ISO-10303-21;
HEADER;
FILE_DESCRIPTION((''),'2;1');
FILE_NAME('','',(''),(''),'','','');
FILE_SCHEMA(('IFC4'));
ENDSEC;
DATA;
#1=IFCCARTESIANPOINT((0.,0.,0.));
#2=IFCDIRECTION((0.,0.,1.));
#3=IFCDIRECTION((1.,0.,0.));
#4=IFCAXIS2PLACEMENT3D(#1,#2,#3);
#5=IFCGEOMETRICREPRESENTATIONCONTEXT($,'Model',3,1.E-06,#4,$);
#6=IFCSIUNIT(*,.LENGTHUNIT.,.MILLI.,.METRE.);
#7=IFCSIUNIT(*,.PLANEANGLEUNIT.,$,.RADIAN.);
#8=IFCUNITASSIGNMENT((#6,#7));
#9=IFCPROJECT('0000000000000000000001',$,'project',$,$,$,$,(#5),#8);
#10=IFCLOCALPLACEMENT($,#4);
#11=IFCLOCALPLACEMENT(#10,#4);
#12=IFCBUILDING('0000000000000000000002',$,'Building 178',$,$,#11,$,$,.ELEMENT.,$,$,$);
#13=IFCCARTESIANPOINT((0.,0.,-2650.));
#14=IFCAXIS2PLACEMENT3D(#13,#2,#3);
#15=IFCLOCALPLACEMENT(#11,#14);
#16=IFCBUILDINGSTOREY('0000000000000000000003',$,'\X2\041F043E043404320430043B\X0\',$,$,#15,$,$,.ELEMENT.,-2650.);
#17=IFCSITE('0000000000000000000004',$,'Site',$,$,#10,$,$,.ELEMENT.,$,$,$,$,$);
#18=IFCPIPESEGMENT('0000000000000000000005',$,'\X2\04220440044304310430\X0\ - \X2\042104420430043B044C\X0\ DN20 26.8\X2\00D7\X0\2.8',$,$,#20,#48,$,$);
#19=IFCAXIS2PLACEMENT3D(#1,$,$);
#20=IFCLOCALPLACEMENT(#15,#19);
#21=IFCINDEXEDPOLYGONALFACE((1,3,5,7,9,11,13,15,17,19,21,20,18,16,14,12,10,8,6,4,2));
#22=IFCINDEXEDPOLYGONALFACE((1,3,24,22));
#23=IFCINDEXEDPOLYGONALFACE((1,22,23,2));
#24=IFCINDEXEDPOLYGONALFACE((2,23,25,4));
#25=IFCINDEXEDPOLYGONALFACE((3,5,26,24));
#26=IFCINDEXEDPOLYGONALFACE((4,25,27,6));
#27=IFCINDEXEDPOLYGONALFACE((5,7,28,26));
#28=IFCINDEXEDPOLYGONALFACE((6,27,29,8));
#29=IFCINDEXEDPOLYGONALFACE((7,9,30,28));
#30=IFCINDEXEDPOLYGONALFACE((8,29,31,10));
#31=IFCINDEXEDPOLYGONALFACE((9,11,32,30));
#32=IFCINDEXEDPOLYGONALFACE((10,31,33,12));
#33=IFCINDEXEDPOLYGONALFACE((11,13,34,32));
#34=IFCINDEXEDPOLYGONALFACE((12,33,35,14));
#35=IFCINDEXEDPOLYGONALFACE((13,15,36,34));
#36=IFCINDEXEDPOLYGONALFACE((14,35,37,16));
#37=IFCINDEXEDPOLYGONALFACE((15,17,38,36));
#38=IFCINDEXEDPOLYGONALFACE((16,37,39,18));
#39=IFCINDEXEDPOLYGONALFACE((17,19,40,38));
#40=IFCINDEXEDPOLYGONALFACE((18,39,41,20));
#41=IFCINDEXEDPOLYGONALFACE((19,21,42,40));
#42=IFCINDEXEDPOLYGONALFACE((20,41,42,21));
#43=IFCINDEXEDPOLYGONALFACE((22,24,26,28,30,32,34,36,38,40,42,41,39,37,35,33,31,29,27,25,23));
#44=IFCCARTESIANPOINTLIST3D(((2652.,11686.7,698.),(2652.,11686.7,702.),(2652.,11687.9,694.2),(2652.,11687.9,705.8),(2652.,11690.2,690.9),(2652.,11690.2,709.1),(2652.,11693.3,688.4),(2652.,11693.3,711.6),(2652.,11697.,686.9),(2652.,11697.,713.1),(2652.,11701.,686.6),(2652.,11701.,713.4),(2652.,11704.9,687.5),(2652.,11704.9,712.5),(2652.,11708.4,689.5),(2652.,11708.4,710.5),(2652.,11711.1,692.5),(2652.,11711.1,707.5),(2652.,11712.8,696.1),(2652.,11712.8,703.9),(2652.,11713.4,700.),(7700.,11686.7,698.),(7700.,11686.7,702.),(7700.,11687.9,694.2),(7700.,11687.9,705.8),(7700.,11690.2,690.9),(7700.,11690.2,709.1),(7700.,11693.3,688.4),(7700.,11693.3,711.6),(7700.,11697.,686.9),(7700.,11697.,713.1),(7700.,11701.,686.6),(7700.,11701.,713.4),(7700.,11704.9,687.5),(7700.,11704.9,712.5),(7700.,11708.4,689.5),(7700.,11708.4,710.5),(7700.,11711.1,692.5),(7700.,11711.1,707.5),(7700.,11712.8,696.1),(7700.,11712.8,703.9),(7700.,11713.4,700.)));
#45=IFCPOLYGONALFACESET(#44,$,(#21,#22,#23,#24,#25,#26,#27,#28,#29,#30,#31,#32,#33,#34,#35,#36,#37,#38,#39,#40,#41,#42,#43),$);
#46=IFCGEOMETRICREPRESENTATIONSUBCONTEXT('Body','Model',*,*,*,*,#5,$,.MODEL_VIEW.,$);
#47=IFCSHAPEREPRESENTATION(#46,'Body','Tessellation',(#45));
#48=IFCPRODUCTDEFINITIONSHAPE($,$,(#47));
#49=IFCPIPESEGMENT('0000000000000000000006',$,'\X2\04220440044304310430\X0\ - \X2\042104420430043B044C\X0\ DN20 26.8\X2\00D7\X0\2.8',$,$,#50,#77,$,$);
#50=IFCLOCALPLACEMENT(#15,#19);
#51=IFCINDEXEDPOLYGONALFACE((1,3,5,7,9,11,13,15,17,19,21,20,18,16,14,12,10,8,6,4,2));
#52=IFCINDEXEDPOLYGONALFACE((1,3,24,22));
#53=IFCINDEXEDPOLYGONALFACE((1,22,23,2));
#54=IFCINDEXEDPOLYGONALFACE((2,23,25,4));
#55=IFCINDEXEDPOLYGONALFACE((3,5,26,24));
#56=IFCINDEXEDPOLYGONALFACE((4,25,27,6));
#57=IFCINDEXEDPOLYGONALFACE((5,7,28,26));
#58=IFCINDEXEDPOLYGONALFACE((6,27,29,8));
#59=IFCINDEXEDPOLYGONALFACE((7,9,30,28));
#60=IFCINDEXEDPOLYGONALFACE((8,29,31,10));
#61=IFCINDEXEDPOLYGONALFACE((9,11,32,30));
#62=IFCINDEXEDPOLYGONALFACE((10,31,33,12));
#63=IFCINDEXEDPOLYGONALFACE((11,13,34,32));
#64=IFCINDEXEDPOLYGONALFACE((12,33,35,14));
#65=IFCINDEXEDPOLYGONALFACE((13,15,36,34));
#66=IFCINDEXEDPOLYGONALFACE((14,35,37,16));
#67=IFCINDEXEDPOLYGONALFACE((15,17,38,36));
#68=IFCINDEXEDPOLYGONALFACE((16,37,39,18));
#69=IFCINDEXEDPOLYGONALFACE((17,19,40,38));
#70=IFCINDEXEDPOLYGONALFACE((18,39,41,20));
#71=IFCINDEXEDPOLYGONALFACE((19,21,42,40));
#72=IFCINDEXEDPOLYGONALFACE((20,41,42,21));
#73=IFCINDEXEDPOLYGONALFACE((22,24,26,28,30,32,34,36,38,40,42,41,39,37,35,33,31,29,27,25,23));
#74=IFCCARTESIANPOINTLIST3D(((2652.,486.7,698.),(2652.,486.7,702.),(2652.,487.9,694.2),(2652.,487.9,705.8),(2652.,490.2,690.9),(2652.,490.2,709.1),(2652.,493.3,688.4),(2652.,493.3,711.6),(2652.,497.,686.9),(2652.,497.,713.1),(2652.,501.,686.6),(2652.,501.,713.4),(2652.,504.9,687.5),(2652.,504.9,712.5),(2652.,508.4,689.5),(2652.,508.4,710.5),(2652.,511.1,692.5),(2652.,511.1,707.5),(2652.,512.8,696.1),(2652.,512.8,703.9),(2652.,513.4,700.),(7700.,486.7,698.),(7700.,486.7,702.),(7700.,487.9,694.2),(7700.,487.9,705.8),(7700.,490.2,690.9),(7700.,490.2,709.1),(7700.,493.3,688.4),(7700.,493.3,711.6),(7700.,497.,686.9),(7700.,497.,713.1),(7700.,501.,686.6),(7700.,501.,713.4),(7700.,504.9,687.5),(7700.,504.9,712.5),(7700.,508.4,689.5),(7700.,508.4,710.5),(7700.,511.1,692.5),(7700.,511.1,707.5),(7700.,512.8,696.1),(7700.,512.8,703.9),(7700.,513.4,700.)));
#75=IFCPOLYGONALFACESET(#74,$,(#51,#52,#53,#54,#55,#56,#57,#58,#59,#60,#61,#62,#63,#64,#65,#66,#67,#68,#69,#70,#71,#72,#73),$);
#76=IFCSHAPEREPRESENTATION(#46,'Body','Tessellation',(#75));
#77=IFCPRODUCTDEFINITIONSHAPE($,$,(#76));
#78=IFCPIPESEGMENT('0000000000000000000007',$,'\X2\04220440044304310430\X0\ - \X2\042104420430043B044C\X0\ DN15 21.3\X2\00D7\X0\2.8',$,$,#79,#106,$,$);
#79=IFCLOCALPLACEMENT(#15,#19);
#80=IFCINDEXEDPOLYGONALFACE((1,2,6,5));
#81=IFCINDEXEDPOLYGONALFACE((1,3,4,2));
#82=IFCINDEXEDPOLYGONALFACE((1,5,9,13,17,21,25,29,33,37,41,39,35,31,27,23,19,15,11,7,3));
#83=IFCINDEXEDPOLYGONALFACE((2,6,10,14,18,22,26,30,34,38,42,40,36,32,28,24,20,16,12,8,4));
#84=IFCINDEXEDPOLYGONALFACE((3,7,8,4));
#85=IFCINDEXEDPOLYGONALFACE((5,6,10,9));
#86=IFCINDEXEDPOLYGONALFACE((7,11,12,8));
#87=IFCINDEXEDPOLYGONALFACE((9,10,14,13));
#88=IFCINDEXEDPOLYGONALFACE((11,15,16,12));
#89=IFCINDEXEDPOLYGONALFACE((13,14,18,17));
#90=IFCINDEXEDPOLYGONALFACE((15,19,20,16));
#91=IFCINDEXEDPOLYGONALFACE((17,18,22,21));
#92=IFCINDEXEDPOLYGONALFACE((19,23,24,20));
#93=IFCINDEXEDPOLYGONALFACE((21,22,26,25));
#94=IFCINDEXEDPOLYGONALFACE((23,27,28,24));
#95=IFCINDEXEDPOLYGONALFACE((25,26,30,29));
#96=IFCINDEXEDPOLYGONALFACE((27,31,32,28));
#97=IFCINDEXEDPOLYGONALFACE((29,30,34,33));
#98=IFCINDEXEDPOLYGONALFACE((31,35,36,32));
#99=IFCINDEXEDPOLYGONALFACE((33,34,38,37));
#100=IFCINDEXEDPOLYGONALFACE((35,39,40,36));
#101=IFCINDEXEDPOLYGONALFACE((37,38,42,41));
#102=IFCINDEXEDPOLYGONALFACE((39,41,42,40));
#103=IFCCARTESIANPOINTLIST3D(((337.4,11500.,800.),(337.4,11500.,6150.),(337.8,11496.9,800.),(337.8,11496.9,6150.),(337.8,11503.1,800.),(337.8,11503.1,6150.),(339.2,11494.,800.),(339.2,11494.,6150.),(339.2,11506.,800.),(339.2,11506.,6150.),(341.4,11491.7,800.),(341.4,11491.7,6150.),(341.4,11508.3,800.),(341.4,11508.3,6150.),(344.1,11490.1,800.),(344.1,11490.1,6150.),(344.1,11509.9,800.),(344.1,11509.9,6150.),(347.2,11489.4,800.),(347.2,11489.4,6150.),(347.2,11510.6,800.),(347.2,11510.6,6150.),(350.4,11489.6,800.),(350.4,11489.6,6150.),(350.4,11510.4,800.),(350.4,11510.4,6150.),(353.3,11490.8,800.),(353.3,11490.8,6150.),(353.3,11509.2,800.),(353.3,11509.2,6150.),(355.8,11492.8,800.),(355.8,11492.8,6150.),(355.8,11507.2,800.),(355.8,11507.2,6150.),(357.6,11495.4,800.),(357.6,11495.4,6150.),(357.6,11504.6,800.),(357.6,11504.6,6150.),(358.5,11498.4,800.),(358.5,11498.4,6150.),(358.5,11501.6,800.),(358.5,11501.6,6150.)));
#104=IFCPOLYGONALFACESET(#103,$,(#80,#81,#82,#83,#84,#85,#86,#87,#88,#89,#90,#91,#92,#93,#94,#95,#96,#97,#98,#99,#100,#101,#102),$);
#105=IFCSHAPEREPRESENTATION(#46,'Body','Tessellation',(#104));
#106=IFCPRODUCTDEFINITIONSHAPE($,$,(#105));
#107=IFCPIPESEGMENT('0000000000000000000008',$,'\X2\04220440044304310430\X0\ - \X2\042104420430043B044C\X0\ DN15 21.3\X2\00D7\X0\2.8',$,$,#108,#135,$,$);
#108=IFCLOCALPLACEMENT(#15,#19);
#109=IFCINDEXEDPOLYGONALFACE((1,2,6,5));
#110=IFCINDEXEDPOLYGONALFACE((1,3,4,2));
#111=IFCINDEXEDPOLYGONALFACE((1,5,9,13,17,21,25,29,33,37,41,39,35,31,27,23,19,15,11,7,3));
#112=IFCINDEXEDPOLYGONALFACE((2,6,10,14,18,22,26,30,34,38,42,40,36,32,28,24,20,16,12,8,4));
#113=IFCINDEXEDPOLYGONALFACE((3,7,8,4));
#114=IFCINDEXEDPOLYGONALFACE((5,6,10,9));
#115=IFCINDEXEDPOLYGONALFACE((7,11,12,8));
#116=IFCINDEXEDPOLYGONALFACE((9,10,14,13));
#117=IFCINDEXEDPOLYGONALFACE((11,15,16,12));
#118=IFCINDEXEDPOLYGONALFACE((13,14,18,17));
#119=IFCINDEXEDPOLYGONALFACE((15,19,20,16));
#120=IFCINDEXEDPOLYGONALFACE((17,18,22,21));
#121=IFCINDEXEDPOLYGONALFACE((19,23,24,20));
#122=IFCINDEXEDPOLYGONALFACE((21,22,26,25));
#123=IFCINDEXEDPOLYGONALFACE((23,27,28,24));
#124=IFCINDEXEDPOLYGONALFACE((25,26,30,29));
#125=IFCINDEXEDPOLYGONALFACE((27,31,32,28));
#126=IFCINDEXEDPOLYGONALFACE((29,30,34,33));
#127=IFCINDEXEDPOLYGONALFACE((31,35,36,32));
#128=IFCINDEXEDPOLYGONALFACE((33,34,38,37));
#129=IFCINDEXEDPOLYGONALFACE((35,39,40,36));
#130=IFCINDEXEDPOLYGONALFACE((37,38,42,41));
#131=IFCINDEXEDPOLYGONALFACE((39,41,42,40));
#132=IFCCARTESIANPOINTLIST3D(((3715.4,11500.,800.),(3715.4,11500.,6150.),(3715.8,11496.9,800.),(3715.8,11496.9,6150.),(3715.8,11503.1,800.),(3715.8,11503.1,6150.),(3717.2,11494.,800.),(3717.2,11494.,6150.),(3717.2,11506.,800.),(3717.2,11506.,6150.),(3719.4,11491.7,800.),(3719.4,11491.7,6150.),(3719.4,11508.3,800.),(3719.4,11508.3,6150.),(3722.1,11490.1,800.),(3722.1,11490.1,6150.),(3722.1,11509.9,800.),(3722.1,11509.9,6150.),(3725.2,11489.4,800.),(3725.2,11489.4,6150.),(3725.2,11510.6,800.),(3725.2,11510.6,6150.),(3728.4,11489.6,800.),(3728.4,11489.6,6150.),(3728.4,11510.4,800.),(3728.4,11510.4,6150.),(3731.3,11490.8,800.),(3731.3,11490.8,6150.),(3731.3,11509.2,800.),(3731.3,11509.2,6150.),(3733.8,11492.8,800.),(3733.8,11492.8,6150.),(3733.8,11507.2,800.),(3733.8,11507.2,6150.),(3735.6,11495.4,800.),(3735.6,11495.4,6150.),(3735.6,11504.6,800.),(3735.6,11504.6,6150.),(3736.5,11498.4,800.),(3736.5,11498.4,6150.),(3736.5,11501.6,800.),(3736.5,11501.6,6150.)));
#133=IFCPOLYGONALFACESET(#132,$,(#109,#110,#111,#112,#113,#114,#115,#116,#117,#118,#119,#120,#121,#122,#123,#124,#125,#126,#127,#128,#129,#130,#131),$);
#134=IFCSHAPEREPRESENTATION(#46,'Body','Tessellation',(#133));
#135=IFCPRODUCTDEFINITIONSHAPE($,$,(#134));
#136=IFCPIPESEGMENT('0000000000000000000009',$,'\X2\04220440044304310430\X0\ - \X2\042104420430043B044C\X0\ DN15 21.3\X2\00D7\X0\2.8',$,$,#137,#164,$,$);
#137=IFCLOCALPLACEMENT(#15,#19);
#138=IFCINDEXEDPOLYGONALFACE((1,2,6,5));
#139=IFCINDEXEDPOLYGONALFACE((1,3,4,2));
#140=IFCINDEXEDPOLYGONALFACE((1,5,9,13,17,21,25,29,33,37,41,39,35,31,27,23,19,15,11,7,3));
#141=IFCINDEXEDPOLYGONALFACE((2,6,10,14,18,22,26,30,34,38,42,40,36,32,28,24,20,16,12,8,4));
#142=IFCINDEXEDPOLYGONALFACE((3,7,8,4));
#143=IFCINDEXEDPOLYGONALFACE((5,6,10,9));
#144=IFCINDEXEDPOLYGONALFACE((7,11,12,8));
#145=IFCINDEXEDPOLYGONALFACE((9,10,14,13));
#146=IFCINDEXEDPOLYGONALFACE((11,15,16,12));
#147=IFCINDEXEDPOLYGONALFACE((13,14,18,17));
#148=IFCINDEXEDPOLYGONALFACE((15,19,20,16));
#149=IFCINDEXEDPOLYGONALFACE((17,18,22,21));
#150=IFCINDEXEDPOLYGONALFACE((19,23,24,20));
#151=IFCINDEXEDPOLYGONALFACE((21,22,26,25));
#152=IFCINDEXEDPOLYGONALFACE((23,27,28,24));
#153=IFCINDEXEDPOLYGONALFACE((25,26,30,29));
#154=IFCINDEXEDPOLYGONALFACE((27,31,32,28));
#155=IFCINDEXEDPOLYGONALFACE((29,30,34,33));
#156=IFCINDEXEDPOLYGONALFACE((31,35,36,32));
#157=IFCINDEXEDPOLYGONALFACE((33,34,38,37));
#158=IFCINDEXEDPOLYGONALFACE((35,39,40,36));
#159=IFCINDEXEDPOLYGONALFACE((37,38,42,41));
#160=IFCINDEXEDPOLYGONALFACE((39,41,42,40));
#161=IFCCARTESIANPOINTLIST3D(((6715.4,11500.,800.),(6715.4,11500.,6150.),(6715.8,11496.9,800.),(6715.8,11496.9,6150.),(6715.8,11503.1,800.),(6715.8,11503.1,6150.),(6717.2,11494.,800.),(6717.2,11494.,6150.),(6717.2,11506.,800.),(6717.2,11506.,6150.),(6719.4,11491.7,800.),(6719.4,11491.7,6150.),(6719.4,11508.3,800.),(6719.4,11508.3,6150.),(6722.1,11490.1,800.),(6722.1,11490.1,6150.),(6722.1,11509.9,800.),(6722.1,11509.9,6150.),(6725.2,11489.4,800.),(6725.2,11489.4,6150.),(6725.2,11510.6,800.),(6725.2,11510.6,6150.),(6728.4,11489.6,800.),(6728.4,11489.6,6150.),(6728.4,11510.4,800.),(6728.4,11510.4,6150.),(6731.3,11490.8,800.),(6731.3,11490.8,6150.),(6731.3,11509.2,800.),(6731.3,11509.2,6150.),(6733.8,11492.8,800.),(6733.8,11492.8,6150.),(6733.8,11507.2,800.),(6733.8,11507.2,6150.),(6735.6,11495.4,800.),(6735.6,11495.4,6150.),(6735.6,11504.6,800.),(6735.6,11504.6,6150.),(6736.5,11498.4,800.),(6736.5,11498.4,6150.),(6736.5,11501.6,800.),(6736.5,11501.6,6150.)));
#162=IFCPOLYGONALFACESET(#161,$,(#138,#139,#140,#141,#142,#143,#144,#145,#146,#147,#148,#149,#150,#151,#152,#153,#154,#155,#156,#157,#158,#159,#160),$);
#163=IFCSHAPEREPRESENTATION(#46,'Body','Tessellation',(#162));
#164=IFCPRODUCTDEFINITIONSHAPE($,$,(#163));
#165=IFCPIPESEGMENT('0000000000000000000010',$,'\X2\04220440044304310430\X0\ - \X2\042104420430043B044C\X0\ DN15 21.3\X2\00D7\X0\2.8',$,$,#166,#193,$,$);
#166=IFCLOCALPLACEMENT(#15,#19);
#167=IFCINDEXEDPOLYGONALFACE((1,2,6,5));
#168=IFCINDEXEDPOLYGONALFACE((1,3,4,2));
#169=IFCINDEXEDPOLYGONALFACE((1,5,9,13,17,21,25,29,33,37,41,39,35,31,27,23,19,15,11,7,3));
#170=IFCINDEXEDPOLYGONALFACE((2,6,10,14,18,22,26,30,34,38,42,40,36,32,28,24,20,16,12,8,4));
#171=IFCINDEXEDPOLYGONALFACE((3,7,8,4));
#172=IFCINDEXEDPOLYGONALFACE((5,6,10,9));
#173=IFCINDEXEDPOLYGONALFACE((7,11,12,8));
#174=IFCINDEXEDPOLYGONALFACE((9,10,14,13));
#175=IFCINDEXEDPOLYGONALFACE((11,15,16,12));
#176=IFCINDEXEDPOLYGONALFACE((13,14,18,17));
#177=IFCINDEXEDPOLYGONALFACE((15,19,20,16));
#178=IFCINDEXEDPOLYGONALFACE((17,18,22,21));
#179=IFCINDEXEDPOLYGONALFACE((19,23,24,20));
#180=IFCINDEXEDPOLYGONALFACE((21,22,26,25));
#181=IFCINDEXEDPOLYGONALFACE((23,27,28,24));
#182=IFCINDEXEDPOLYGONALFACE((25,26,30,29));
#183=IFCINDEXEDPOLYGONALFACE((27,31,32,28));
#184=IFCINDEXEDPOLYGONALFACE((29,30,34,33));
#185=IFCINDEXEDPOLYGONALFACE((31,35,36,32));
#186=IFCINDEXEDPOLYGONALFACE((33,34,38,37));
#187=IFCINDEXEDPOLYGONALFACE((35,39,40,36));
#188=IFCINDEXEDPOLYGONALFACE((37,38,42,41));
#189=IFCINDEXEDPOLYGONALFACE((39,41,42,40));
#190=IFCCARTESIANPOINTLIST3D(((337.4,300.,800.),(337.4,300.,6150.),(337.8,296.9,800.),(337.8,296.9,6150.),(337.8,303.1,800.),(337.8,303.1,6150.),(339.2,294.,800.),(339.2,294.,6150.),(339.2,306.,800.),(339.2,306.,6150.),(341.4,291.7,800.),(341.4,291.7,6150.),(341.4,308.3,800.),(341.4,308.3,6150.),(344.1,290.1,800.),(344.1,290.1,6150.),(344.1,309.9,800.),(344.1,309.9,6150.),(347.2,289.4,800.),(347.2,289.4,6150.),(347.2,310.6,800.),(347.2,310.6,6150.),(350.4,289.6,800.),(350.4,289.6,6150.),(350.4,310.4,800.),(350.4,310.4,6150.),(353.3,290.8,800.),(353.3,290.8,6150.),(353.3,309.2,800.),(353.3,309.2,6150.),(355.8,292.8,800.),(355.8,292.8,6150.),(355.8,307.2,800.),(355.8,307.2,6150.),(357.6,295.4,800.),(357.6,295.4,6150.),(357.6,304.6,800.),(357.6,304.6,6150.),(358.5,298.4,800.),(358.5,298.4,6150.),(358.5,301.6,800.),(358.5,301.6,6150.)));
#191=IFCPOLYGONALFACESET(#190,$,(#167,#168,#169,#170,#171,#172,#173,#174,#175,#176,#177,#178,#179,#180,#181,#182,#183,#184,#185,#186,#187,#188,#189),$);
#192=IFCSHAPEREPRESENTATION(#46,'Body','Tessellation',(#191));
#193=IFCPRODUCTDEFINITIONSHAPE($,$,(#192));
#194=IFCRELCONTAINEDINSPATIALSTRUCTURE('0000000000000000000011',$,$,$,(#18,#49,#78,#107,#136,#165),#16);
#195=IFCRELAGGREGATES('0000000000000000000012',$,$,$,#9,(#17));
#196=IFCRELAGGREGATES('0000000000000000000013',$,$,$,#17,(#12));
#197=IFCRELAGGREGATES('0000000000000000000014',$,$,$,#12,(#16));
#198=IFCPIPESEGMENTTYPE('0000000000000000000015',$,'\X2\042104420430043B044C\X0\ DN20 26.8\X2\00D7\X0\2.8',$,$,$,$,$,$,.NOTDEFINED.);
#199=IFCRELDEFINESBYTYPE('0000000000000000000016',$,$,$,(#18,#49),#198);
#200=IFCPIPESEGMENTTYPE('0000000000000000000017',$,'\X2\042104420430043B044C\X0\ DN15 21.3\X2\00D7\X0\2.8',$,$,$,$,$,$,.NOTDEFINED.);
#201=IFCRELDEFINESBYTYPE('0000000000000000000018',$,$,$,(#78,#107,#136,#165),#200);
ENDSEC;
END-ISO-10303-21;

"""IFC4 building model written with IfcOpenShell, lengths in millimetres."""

from ifc_helpers import new_model, entity, si_unit, frame, origin_with_axes, place, context, subcontext, project, spatial, source, transform, mapped, type_object, element, save


model = new_model("IFC4")

# Units and contexts
model_context = context("Model", 3, precision=1e-06, world=origin_with_axes())
body_context = subcontext(model_context, "Body", "Model", "MODEL_VIEW")
ifc_project = project(units=[si_unit("LENGTHUNIT", "METRE", prefix="MILLI"), si_unit("PLANEANGLEUNIT", "RADIAN")], contexts=[model_context])

# Site, building, storey
site_placement = place(None, origin_with_axes())
site = spatial("IfcSite", under=ifc_project, at=site_placement, Name="Site", CompositionType="ELEMENT")
building_placement = place(site_placement, origin_with_axes())
building = spatial("IfcBuilding", under=site, at=building_placement, Name="Building 178", CompositionType="ELEMENT")
storey_placement = place(building_placement, frame((0.0, 0.0, -2650.0), z_axis=(0.0, 0.0, 1.0), x_axis=(1.0, 0.0, 0.0)))
storey = spatial("IfcBuildingStorey", under=building, at=storey_placement, Name="Подвал", CompositionType="ELEMENT", Elevation=-2650.0)

# Pipe segments
pipe_segment_type_1 = type_object("IfcPipeSegmentType", Name="Сталь DN20 26.8×2.8", PredefinedType="NOTDEFINED")
shared_shape_1 = source(origin_with_axes(), body_context, "Body", "AdvancedSweptSolid", [
    entity("IfcSweptDiskSolid", entity("IfcIndexedPolyCurve", entity("IfcCartesianPointList3D", [[0.0, 0.0, 0.0], [0.0, 0.0, -5048.0]]), [entity("IfcLineIndex", [1, 2])]), 13.4),
])
for number, where, z_axis, x_axis, name in (
    (1, (2652.0, 11700.0, 700.0), (-1.0, 0.0, 0.0), (0.0, -1.0, 0.0), "Труба - Сталь DN20 26.8×2.8"),
    (2, (2652.0, 500.0, 700.0), (-1.0, 0.0, 0.0), (0.0, -1.0, 0.0), "Труба - Сталь DN20 26.8×2.8"),
):
    element("IfcPipeSegment", number, at=place(storey_placement, frame(where, z_axis=z_axis, x_axis=x_axis)), inside=storey, type_object=pipe_segment_type_1, Name=name, context=body_context, shape_type="MappedRepresentation", body=[
        mapped(shared_shape_1, transform((0.0, 0.0, 0.0), x_axis=(1.0, 0.0, 0.0), y_axis=(0.0, 1.0, 0.0), z_axis=(0.0, 0.0, 1.0), scale=1.0)),
    ])
pipe_segment_type_2 = type_object("IfcPipeSegmentType", Name="Сталь DN15 21.3×2.8", PredefinedType="NOTDEFINED")
shared_shape_2 = source(origin_with_axes(), body_context, "Body", "AdvancedSweptSolid", [
    entity("IfcSweptDiskSolid", entity("IfcIndexedPolyCurve", entity("IfcCartesianPointList3D", [[0.0, 0.0, 0.0], [0.0, 0.0, -5350.0]]), [entity("IfcLineIndex", [1, 2])]), 10.7),
])
for number, where, z_axis, x_axis, name in (
    (3, (348.0, 11500.0, 6150.0), (0.0, 0.0, 1.0), (1.0, 0.0, 0.0), "Труба - Сталь DN15 21.3×2.8"),
    (4, (3726.0, 11500.0, 6150.0), (0.0, 0.0, 1.0), (1.0, 0.0, 0.0), "Труба - Сталь DN15 21.3×2.8"),
    (5, (6726.0, 11500.0, 6150.0), (0.0, 0.0, 1.0), (1.0, 0.0, 0.0), "Труба - Сталь DN15 21.3×2.8"),
    (6, (348.0, 300.0, 6150.0), (0.0, 0.0, 1.0), (1.0, 0.0, 0.0), "Труба - Сталь DN15 21.3×2.8"),
):
    element("IfcPipeSegment", number, at=place(storey_placement, frame(where, z_axis=z_axis, x_axis=x_axis)), inside=storey, type_object=pipe_segment_type_2, Name=name, context=body_context, shape_type="MappedRepresentation", body=[
        mapped(shared_shape_2, transform((0.0, 0.0, 0.0), x_axis=(1.0, 0.0, 0.0), y_axis=(0.0, 1.0, 0.0), z_axis=(0.0, 0.0, 1.0), scale=1.0)),
    ])

save(model, "model.ifc")
